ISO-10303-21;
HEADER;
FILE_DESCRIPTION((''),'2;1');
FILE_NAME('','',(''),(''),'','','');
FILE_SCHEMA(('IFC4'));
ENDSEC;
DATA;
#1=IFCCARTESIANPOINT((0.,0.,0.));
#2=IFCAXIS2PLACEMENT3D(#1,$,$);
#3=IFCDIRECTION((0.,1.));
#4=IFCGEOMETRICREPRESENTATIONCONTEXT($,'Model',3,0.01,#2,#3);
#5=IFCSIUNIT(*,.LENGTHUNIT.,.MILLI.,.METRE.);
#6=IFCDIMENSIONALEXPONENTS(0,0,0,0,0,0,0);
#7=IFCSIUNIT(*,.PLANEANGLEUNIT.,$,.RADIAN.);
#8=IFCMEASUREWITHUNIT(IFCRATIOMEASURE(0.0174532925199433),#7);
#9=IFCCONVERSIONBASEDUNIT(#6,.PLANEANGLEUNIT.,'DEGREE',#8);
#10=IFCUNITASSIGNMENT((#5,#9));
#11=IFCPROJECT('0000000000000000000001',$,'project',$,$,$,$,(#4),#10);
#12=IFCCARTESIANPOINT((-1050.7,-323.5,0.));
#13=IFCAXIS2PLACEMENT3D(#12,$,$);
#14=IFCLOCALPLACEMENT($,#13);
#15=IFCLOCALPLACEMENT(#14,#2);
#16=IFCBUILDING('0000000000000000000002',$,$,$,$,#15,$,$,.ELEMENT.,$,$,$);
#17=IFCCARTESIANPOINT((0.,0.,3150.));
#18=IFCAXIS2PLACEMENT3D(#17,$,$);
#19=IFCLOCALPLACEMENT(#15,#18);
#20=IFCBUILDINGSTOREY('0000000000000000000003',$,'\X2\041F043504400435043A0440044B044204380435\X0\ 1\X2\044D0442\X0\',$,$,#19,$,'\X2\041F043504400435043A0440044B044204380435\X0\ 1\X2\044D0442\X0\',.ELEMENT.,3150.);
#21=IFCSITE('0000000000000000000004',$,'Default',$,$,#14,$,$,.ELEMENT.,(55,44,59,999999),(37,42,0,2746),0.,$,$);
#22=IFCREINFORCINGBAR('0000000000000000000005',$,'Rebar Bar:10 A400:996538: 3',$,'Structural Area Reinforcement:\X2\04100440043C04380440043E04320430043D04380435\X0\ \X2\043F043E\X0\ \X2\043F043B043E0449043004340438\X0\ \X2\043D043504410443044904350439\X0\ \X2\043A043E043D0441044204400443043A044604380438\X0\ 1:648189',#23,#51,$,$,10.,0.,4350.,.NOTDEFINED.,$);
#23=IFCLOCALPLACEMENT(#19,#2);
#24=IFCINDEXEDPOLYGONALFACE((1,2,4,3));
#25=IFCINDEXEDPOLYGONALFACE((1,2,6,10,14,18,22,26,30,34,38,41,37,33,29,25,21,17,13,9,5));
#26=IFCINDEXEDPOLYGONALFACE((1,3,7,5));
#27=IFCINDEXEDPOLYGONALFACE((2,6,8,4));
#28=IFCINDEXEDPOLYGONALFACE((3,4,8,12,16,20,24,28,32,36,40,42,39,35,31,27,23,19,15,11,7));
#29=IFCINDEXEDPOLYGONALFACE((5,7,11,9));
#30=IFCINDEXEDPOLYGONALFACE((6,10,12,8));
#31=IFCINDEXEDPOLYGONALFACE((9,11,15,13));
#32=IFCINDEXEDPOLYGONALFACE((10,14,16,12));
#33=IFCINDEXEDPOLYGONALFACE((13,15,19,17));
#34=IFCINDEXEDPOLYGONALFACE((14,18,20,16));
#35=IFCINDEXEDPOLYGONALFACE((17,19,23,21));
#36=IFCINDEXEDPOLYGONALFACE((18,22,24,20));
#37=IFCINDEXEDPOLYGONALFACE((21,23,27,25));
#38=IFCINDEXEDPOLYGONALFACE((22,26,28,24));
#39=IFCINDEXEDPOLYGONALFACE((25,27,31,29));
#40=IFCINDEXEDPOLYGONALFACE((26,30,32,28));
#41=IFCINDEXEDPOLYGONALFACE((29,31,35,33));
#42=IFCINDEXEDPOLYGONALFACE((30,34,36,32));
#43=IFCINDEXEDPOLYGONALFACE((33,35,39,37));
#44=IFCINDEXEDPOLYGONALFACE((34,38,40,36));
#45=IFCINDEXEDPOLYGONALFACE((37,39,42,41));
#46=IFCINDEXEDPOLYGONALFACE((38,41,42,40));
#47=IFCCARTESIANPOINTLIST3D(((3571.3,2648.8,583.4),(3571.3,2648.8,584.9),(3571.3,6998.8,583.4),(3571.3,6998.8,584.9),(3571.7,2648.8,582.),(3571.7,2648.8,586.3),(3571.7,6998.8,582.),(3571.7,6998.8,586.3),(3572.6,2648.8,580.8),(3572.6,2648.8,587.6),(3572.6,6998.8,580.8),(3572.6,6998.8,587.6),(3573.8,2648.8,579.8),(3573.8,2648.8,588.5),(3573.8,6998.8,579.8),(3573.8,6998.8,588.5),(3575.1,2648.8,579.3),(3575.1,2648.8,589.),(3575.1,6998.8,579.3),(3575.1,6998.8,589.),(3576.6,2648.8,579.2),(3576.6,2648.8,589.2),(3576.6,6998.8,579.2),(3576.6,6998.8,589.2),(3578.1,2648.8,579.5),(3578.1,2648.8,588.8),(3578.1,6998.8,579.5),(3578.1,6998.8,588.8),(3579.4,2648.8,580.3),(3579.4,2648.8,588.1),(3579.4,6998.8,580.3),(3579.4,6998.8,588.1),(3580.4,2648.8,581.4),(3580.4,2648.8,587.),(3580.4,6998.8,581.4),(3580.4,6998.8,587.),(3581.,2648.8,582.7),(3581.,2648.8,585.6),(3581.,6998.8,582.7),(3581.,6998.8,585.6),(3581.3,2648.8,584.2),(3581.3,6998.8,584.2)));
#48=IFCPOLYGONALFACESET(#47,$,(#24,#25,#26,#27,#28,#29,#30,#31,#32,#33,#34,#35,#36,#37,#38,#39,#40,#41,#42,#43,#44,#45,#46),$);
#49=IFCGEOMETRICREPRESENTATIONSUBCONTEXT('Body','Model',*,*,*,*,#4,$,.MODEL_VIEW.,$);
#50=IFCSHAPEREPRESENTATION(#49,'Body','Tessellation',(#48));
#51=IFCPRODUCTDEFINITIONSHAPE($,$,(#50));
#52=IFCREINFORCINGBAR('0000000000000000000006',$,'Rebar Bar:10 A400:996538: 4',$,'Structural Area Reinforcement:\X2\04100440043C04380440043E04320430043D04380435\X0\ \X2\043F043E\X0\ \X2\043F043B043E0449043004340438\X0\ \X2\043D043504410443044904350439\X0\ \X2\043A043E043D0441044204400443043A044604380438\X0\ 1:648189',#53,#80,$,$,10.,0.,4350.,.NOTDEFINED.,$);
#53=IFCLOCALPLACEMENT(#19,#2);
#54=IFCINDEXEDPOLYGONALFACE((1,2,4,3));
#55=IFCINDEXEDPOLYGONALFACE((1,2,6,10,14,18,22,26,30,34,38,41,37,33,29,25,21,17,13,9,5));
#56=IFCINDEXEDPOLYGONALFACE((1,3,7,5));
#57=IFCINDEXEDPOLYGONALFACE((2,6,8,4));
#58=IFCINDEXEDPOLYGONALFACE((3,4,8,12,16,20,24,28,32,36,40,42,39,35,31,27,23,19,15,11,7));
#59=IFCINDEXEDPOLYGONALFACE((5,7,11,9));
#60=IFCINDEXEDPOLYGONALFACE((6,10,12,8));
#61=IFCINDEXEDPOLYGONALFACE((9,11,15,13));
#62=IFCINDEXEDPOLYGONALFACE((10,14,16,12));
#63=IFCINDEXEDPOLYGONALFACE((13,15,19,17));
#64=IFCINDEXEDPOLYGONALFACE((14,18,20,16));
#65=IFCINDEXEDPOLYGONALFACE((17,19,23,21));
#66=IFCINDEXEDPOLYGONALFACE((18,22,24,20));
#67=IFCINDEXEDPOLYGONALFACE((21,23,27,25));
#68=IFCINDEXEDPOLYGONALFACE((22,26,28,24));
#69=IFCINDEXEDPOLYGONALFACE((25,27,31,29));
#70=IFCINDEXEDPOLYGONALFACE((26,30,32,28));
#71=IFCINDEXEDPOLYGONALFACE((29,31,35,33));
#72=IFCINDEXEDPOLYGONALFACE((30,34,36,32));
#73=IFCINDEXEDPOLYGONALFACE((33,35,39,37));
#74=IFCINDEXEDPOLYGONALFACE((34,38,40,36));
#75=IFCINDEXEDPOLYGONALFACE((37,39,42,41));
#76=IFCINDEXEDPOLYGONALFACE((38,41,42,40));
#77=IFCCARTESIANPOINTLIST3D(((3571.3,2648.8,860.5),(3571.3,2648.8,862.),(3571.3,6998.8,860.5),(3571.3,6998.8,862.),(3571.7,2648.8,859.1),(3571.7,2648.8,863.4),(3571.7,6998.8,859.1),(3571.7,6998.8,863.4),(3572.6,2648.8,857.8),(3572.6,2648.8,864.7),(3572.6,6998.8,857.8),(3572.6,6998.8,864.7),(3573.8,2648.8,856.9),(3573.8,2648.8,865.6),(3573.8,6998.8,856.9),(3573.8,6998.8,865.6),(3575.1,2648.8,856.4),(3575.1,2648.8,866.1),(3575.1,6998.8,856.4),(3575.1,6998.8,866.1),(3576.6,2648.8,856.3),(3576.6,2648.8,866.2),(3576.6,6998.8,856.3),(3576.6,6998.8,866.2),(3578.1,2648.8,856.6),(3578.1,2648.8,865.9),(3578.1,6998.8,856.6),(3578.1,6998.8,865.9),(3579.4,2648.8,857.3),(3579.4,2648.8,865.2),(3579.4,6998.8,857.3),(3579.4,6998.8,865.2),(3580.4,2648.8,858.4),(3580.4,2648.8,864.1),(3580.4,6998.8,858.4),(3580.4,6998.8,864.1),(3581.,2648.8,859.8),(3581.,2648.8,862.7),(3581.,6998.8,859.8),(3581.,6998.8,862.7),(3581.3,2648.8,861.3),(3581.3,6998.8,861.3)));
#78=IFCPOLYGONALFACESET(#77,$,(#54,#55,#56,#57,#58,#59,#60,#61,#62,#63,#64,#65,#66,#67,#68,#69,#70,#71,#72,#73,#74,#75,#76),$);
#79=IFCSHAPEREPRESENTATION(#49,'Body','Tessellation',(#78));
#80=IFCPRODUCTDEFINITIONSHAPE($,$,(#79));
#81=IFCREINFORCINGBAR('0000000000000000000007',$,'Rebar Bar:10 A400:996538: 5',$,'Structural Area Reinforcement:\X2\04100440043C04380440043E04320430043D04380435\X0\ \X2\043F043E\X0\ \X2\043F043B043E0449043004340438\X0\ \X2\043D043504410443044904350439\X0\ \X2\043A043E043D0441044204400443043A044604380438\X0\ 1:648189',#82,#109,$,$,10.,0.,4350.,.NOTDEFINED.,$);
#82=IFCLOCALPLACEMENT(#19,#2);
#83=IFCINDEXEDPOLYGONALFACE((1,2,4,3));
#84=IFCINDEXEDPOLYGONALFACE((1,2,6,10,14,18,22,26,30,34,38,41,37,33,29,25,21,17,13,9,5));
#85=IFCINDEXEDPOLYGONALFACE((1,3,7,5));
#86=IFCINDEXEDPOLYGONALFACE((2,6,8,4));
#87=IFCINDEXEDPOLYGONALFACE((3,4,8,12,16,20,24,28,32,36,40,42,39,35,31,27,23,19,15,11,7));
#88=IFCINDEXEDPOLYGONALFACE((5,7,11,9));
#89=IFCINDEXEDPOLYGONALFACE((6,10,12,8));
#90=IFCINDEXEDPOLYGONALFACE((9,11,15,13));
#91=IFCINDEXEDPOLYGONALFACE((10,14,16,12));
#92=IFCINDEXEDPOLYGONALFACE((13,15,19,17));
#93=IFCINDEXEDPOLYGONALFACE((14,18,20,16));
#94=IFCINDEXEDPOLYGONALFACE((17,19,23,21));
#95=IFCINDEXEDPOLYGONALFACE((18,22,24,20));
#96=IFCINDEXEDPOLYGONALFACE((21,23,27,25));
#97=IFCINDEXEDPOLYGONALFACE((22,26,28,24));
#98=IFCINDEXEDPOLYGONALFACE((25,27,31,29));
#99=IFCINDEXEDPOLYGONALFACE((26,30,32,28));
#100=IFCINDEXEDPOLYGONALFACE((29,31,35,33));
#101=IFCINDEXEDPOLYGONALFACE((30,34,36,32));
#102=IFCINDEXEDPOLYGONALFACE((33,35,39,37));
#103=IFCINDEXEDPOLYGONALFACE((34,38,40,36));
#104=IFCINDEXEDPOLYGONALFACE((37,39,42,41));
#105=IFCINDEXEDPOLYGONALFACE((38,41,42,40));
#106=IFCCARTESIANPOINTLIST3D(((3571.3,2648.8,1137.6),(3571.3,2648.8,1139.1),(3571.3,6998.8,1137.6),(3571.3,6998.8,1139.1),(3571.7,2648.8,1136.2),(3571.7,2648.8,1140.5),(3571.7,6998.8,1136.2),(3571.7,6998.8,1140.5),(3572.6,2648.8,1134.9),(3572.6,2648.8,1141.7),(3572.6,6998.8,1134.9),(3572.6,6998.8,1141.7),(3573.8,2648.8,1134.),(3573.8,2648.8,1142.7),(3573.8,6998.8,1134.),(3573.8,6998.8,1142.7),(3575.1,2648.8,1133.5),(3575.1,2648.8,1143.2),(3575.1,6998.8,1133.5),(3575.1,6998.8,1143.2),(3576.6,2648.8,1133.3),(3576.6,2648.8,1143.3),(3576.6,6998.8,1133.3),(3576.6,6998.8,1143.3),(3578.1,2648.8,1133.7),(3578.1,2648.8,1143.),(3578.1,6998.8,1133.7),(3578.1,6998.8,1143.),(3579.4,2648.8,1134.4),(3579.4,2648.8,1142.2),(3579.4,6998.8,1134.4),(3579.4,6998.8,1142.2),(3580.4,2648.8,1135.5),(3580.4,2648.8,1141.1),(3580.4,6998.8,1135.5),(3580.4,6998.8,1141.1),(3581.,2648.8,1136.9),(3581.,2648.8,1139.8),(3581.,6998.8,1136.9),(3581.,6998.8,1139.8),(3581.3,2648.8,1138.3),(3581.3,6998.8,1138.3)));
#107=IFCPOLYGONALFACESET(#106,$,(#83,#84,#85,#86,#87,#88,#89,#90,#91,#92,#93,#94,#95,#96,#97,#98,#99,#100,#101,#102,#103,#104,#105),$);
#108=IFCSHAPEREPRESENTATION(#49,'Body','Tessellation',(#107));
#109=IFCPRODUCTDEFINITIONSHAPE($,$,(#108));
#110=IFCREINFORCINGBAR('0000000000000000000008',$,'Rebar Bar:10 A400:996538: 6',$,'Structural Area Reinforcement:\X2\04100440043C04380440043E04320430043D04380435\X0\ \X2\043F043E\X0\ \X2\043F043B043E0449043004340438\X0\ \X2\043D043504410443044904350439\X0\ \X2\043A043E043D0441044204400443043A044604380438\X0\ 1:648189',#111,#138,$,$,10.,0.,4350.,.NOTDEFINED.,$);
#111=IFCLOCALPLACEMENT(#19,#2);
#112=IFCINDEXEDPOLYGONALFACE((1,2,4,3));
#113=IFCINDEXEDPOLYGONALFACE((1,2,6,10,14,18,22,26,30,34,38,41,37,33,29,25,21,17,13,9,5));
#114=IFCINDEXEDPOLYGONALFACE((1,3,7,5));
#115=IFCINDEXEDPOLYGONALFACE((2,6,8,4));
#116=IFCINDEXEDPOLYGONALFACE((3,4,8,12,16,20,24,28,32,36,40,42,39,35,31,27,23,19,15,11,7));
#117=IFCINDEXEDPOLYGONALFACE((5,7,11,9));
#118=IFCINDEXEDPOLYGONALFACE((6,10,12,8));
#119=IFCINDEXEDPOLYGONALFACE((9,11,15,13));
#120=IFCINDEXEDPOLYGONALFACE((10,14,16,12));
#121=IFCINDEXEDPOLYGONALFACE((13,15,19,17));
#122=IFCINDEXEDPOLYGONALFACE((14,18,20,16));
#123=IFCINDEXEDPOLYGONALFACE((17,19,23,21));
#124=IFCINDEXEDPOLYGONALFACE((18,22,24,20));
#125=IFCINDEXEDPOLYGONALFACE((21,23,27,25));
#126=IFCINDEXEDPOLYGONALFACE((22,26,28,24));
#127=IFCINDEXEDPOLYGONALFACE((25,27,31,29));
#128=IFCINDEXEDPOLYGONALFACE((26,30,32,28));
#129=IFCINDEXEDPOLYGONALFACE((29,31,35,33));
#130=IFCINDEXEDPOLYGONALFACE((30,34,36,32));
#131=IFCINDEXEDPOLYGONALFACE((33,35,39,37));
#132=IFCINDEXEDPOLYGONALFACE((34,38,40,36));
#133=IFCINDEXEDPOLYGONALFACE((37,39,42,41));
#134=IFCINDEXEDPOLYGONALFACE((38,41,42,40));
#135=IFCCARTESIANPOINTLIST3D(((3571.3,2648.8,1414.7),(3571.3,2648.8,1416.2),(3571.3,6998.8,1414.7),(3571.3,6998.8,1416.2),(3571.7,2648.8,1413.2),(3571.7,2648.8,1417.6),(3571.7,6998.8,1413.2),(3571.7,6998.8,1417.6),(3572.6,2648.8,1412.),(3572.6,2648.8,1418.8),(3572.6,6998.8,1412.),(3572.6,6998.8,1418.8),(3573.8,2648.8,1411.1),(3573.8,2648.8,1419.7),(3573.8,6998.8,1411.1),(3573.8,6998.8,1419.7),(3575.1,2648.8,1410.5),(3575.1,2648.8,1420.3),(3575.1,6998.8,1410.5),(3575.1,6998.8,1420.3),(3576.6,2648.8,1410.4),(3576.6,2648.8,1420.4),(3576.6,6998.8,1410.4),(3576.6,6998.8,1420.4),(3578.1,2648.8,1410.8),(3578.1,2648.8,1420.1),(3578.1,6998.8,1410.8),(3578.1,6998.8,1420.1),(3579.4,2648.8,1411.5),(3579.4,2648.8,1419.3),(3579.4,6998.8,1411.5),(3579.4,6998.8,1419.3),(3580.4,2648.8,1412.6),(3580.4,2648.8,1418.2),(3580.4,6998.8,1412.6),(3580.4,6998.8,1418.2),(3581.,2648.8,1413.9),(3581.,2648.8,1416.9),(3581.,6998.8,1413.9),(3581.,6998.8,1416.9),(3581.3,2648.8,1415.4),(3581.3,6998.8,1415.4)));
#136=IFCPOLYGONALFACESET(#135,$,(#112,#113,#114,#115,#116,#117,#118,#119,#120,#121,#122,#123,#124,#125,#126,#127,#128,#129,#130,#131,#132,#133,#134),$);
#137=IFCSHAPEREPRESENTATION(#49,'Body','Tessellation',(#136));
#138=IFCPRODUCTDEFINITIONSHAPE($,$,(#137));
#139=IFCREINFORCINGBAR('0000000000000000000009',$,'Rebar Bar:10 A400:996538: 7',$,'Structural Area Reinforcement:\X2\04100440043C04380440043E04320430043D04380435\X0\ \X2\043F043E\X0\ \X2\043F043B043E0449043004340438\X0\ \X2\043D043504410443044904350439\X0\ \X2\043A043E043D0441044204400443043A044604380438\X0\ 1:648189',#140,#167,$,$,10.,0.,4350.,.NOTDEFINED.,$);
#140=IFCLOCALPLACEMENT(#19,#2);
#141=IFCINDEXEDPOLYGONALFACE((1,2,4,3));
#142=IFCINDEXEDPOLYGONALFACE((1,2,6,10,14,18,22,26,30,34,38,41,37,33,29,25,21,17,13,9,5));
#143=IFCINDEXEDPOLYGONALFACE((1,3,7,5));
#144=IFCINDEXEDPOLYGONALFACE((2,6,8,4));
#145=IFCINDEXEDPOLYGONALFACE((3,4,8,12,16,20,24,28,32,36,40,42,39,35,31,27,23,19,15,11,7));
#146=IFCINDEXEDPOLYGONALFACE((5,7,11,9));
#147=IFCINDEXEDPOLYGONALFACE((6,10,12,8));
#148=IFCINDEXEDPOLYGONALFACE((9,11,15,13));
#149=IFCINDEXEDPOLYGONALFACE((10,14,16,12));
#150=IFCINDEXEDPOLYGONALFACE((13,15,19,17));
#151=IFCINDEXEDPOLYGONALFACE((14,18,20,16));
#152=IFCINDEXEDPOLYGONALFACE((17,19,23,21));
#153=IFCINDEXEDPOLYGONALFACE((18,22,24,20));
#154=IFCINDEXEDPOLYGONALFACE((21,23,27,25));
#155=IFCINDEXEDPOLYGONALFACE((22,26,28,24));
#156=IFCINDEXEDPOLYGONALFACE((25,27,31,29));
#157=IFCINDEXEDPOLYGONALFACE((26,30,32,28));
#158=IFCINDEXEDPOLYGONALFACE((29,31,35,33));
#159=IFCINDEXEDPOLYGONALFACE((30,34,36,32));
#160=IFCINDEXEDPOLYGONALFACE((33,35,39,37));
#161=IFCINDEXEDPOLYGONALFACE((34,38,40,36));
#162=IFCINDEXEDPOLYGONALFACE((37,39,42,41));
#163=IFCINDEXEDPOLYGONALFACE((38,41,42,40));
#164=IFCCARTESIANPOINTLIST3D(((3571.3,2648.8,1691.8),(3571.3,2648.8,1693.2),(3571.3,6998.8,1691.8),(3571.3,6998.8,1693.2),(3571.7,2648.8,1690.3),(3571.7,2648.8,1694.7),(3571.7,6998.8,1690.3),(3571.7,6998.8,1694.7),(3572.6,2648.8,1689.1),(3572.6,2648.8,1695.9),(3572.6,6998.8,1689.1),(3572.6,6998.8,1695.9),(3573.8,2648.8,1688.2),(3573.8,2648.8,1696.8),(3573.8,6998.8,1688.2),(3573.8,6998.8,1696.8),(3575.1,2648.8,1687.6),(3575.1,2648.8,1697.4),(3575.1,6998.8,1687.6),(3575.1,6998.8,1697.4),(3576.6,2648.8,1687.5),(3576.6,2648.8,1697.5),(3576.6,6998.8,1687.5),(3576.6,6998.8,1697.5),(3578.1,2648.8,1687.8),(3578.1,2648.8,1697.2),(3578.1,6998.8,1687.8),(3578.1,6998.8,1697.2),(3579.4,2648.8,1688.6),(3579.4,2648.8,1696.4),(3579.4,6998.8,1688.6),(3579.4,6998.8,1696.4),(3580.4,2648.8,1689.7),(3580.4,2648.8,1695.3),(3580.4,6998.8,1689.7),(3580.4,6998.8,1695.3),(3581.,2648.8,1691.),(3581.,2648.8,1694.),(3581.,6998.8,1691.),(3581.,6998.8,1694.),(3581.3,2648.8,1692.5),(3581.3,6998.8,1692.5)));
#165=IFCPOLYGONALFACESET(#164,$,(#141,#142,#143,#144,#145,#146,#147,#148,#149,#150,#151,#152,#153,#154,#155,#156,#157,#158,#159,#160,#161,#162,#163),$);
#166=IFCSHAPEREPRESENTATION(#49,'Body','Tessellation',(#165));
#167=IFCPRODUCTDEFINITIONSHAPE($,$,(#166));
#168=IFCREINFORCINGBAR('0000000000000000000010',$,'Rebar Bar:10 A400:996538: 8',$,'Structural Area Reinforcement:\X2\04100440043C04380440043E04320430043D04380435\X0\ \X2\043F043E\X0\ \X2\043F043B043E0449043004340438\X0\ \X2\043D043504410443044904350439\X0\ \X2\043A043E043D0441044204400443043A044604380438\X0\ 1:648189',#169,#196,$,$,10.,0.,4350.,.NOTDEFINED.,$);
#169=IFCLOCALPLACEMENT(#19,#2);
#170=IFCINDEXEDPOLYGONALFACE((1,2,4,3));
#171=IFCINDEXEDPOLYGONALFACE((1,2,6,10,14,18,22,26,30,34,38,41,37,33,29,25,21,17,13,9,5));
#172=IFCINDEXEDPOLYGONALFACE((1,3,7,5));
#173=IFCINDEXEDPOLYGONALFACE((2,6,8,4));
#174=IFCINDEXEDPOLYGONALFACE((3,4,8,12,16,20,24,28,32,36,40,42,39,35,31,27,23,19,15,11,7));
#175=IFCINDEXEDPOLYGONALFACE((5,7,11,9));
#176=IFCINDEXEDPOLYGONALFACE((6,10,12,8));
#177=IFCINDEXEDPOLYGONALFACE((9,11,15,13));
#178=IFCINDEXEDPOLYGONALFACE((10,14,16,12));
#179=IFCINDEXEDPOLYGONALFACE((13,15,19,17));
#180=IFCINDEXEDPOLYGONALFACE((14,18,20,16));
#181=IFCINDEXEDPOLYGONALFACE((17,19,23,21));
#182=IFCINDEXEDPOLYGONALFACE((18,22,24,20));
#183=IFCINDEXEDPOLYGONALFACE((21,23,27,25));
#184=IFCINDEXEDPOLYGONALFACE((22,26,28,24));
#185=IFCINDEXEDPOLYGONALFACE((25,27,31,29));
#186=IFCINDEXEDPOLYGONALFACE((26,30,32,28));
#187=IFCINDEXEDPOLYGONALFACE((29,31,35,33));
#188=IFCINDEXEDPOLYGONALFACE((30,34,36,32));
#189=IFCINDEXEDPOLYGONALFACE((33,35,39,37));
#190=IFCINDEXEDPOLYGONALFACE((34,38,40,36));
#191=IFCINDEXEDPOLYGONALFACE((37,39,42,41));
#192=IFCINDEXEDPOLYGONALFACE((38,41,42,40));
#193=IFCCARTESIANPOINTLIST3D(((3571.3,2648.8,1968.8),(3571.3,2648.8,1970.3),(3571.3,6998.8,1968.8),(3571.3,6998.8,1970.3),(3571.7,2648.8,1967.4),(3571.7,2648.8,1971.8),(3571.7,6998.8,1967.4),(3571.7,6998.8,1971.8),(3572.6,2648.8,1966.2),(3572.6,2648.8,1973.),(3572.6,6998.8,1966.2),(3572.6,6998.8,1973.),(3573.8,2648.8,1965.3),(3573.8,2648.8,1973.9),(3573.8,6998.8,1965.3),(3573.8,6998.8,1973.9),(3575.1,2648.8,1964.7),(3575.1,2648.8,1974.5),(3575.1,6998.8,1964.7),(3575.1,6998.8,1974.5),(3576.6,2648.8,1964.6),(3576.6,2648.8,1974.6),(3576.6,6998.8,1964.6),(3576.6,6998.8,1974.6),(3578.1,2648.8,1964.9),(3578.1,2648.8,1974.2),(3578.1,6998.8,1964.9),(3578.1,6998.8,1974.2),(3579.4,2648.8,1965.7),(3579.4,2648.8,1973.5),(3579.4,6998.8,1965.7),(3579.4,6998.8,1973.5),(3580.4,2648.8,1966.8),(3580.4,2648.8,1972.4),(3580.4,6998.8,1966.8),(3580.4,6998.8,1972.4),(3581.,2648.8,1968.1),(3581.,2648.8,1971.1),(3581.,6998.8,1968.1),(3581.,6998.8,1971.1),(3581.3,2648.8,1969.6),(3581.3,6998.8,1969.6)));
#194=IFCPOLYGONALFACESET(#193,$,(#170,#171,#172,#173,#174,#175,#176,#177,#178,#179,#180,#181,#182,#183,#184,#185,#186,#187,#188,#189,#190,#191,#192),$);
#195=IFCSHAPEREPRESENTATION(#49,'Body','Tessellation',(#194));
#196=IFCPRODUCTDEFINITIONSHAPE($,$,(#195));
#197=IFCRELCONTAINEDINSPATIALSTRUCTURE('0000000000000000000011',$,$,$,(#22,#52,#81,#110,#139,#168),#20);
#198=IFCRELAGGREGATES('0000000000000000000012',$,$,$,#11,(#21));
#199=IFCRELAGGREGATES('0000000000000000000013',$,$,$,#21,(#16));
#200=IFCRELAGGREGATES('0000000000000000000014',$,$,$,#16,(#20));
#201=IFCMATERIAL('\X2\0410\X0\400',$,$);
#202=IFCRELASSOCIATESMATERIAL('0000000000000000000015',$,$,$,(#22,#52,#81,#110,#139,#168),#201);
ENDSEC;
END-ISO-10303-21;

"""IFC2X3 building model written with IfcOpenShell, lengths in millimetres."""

from ifc_helpers import new_model, entity, si_unit, converted_unit, direction, frame, origin, place, context, subcontext, project, spatial, material, element, save


model = new_model("IFC2X3")

# Units and contexts
model_context = context("Model", 3, precision=0.01, world=origin(), true_north=direction((0.0, 1.0)))
body_context = subcontext(model_context, "Body", "Model", "MODEL_VIEW")
ifc_project = project(units=[si_unit("LENGTHUNIT", "METRE", prefix="MILLI"), converted_unit("PLANEANGLEUNIT", "DEGREE", entity("IfcRatioMeasure", 0.0174532925199433), si_unit("PLANEANGLEUNIT", "RADIAN"), dimensions=[0, 0, 0, 0, 0, 0, 0])], contexts=[model_context])

# Site, building, storey
site_placement = place(None, frame((-1050.7, -323.5, 0.0)))
site = spatial("IfcSite", under=ifc_project, at=site_placement, Name="Default", CompositionType="ELEMENT", RefLatitude=(55, 44, 59, 999999), RefLongitude=(37, 42, 0, 2746), RefElevation=0.0)
building_placement = place(site_placement, origin())
building = spatial("IfcBuilding", under=site, at=building_placement, CompositionType="ELEMENT")
storey_placement = place(building_placement, frame((0.0, 0.0, 3150.0)))
storey = spatial("IfcBuildingStorey", under=building, at=storey_placement, Name="Перекрытие 1эт", LongName="Перекрытие 1эт", CompositionType="ELEMENT", Elevation=3150.0)

# Reinforcing bars
ifc_material = material(Name="А400")
reinforcing_bar_1_placement = place(storey_placement, origin())
element("IfcReinforcingBar", 1, at=reinforcing_bar_1_placement, inside=storey, material=ifc_material, Name="Rebar Bar:10 A400:996538: 3", ObjectType="Structural Area Reinforcement:Армирование по площади несущей конструкции 1:648189", BarLength=4350.0, BarRole="NOTDEFINED", CrossSectionArea=0.0, NominalDiameter=10.0, context=body_context, shape_type="AdvancedSweptSolid", body=[
    entity("IfcSweptDiskSolid", entity("IfcCompositeCurve", [entity("IfcCompositeCurveSegment", "CONTINUOUS", True, entity("IfcPolyline", [entity("IfcCartesianPoint", [3576.3, 2648.8, 584.2]), entity("IfcCartesianPoint", [3576.3, 6998.8, 584.2])]))], False), 5.0, None, 0.0, 1.0),
])
reinforcing_bar_2_placement = place(storey_placement, origin())
element("IfcReinforcingBar", 2, at=reinforcing_bar_2_placement, inside=storey, material=ifc_material, Name="Rebar Bar:10 A400:996538: 4", ObjectType="Structural Area Reinforcement:Армирование по площади несущей конструкции 1:648189", BarLength=4350.0, BarRole="NOTDEFINED", CrossSectionArea=0.0, NominalDiameter=10.0, context=body_context, shape_type="AdvancedSweptSolid", body=[
    entity("IfcSweptDiskSolid", entity("IfcCompositeCurve", [entity("IfcCompositeCurveSegment", "CONTINUOUS", True, entity("IfcPolyline", [entity("IfcCartesianPoint", [3576.3, 2648.8, 861.3]), entity("IfcCartesianPoint", [3576.3, 6998.8, 861.3])]))], False), 5.0, None, 0.0, 1.0),
])
reinforcing_bar_3_placement = place(storey_placement, origin())
element("IfcReinforcingBar", 3, at=reinforcing_bar_3_placement, inside=storey, material=ifc_material, Name="Rebar Bar:10 A400:996538: 5", ObjectType="Structural Area Reinforcement:Армирование по площади несущей конструкции 1:648189", BarLength=4350.0, BarRole="NOTDEFINED", CrossSectionArea=0.0, NominalDiameter=10.0, context=body_context, shape_type="AdvancedSweptSolid", body=[
    entity("IfcSweptDiskSolid", entity("IfcCompositeCurve", [entity("IfcCompositeCurveSegment", "CONTINUOUS", True, entity("IfcPolyline", [entity("IfcCartesianPoint", [3576.3, 2648.8, 1138.3]), entity("IfcCartesianPoint", [3576.3, 6998.8, 1138.3])]))], False), 5.0, None, 0.0, 1.0),
])
reinforcing_bar_4_placement = place(storey_placement, origin())
element("IfcReinforcingBar", 4, at=reinforcing_bar_4_placement, inside=storey, material=ifc_material, Name="Rebar Bar:10 A400:996538: 6", ObjectType="Structural Area Reinforcement:Армирование по площади несущей конструкции 1:648189", BarLength=4350.0, BarRole="NOTDEFINED", CrossSectionArea=0.0, NominalDiameter=10.0, context=body_context, shape_type="AdvancedSweptSolid", body=[
    entity("IfcSweptDiskSolid", entity("IfcCompositeCurve", [entity("IfcCompositeCurveSegment", "CONTINUOUS", True, entity("IfcPolyline", [entity("IfcCartesianPoint", [3576.3, 2648.8, 1415.4]), entity("IfcCartesianPoint", [3576.3, 6998.8, 1415.4])]))], False), 5.0, None, 0.0, 1.0),
])
reinforcing_bar_5_placement = place(storey_placement, origin())
element("IfcReinforcingBar", 5, at=reinforcing_bar_5_placement, inside=storey, material=ifc_material, Name="Rebar Bar:10 A400:996538: 7", ObjectType="Structural Area Reinforcement:Армирование по площади несущей конструкции 1:648189", BarLength=4350.0, BarRole="NOTDEFINED", CrossSectionArea=0.0, NominalDiameter=10.0, context=body_context, shape_type="AdvancedSweptSolid", body=[
    entity("IfcSweptDiskSolid", entity("IfcCompositeCurve", [entity("IfcCompositeCurveSegment", "CONTINUOUS", True, entity("IfcPolyline", [entity("IfcCartesianPoint", [3576.3, 2648.8, 1692.5]), entity("IfcCartesianPoint", [3576.3, 6998.8, 1692.5])]))], False), 5.0, None, 0.0, 1.0),
])
reinforcing_bar_6_placement = place(storey_placement, origin())
element("IfcReinforcingBar", 6, at=reinforcing_bar_6_placement, inside=storey, material=ifc_material, Name="Rebar Bar:10 A400:996538: 8", ObjectType="Structural Area Reinforcement:Армирование по площади несущей конструкции 1:648189", BarLength=4350.0, BarRole="NOTDEFINED", CrossSectionArea=0.0, NominalDiameter=10.0, context=body_context, shape_type="AdvancedSweptSolid", body=[
    entity("IfcSweptDiskSolid", entity("IfcCompositeCurve", [entity("IfcCompositeCurveSegment", "CONTINUOUS", True, entity("IfcPolyline", [entity("IfcCartesianPoint", [3576.3, 2648.8, 1969.6]), entity("IfcCartesianPoint", [3576.3, 6998.8, 1969.6])]))], False), 5.0, None, 0.0, 1.0),
])

save(model, "model.ifc")
